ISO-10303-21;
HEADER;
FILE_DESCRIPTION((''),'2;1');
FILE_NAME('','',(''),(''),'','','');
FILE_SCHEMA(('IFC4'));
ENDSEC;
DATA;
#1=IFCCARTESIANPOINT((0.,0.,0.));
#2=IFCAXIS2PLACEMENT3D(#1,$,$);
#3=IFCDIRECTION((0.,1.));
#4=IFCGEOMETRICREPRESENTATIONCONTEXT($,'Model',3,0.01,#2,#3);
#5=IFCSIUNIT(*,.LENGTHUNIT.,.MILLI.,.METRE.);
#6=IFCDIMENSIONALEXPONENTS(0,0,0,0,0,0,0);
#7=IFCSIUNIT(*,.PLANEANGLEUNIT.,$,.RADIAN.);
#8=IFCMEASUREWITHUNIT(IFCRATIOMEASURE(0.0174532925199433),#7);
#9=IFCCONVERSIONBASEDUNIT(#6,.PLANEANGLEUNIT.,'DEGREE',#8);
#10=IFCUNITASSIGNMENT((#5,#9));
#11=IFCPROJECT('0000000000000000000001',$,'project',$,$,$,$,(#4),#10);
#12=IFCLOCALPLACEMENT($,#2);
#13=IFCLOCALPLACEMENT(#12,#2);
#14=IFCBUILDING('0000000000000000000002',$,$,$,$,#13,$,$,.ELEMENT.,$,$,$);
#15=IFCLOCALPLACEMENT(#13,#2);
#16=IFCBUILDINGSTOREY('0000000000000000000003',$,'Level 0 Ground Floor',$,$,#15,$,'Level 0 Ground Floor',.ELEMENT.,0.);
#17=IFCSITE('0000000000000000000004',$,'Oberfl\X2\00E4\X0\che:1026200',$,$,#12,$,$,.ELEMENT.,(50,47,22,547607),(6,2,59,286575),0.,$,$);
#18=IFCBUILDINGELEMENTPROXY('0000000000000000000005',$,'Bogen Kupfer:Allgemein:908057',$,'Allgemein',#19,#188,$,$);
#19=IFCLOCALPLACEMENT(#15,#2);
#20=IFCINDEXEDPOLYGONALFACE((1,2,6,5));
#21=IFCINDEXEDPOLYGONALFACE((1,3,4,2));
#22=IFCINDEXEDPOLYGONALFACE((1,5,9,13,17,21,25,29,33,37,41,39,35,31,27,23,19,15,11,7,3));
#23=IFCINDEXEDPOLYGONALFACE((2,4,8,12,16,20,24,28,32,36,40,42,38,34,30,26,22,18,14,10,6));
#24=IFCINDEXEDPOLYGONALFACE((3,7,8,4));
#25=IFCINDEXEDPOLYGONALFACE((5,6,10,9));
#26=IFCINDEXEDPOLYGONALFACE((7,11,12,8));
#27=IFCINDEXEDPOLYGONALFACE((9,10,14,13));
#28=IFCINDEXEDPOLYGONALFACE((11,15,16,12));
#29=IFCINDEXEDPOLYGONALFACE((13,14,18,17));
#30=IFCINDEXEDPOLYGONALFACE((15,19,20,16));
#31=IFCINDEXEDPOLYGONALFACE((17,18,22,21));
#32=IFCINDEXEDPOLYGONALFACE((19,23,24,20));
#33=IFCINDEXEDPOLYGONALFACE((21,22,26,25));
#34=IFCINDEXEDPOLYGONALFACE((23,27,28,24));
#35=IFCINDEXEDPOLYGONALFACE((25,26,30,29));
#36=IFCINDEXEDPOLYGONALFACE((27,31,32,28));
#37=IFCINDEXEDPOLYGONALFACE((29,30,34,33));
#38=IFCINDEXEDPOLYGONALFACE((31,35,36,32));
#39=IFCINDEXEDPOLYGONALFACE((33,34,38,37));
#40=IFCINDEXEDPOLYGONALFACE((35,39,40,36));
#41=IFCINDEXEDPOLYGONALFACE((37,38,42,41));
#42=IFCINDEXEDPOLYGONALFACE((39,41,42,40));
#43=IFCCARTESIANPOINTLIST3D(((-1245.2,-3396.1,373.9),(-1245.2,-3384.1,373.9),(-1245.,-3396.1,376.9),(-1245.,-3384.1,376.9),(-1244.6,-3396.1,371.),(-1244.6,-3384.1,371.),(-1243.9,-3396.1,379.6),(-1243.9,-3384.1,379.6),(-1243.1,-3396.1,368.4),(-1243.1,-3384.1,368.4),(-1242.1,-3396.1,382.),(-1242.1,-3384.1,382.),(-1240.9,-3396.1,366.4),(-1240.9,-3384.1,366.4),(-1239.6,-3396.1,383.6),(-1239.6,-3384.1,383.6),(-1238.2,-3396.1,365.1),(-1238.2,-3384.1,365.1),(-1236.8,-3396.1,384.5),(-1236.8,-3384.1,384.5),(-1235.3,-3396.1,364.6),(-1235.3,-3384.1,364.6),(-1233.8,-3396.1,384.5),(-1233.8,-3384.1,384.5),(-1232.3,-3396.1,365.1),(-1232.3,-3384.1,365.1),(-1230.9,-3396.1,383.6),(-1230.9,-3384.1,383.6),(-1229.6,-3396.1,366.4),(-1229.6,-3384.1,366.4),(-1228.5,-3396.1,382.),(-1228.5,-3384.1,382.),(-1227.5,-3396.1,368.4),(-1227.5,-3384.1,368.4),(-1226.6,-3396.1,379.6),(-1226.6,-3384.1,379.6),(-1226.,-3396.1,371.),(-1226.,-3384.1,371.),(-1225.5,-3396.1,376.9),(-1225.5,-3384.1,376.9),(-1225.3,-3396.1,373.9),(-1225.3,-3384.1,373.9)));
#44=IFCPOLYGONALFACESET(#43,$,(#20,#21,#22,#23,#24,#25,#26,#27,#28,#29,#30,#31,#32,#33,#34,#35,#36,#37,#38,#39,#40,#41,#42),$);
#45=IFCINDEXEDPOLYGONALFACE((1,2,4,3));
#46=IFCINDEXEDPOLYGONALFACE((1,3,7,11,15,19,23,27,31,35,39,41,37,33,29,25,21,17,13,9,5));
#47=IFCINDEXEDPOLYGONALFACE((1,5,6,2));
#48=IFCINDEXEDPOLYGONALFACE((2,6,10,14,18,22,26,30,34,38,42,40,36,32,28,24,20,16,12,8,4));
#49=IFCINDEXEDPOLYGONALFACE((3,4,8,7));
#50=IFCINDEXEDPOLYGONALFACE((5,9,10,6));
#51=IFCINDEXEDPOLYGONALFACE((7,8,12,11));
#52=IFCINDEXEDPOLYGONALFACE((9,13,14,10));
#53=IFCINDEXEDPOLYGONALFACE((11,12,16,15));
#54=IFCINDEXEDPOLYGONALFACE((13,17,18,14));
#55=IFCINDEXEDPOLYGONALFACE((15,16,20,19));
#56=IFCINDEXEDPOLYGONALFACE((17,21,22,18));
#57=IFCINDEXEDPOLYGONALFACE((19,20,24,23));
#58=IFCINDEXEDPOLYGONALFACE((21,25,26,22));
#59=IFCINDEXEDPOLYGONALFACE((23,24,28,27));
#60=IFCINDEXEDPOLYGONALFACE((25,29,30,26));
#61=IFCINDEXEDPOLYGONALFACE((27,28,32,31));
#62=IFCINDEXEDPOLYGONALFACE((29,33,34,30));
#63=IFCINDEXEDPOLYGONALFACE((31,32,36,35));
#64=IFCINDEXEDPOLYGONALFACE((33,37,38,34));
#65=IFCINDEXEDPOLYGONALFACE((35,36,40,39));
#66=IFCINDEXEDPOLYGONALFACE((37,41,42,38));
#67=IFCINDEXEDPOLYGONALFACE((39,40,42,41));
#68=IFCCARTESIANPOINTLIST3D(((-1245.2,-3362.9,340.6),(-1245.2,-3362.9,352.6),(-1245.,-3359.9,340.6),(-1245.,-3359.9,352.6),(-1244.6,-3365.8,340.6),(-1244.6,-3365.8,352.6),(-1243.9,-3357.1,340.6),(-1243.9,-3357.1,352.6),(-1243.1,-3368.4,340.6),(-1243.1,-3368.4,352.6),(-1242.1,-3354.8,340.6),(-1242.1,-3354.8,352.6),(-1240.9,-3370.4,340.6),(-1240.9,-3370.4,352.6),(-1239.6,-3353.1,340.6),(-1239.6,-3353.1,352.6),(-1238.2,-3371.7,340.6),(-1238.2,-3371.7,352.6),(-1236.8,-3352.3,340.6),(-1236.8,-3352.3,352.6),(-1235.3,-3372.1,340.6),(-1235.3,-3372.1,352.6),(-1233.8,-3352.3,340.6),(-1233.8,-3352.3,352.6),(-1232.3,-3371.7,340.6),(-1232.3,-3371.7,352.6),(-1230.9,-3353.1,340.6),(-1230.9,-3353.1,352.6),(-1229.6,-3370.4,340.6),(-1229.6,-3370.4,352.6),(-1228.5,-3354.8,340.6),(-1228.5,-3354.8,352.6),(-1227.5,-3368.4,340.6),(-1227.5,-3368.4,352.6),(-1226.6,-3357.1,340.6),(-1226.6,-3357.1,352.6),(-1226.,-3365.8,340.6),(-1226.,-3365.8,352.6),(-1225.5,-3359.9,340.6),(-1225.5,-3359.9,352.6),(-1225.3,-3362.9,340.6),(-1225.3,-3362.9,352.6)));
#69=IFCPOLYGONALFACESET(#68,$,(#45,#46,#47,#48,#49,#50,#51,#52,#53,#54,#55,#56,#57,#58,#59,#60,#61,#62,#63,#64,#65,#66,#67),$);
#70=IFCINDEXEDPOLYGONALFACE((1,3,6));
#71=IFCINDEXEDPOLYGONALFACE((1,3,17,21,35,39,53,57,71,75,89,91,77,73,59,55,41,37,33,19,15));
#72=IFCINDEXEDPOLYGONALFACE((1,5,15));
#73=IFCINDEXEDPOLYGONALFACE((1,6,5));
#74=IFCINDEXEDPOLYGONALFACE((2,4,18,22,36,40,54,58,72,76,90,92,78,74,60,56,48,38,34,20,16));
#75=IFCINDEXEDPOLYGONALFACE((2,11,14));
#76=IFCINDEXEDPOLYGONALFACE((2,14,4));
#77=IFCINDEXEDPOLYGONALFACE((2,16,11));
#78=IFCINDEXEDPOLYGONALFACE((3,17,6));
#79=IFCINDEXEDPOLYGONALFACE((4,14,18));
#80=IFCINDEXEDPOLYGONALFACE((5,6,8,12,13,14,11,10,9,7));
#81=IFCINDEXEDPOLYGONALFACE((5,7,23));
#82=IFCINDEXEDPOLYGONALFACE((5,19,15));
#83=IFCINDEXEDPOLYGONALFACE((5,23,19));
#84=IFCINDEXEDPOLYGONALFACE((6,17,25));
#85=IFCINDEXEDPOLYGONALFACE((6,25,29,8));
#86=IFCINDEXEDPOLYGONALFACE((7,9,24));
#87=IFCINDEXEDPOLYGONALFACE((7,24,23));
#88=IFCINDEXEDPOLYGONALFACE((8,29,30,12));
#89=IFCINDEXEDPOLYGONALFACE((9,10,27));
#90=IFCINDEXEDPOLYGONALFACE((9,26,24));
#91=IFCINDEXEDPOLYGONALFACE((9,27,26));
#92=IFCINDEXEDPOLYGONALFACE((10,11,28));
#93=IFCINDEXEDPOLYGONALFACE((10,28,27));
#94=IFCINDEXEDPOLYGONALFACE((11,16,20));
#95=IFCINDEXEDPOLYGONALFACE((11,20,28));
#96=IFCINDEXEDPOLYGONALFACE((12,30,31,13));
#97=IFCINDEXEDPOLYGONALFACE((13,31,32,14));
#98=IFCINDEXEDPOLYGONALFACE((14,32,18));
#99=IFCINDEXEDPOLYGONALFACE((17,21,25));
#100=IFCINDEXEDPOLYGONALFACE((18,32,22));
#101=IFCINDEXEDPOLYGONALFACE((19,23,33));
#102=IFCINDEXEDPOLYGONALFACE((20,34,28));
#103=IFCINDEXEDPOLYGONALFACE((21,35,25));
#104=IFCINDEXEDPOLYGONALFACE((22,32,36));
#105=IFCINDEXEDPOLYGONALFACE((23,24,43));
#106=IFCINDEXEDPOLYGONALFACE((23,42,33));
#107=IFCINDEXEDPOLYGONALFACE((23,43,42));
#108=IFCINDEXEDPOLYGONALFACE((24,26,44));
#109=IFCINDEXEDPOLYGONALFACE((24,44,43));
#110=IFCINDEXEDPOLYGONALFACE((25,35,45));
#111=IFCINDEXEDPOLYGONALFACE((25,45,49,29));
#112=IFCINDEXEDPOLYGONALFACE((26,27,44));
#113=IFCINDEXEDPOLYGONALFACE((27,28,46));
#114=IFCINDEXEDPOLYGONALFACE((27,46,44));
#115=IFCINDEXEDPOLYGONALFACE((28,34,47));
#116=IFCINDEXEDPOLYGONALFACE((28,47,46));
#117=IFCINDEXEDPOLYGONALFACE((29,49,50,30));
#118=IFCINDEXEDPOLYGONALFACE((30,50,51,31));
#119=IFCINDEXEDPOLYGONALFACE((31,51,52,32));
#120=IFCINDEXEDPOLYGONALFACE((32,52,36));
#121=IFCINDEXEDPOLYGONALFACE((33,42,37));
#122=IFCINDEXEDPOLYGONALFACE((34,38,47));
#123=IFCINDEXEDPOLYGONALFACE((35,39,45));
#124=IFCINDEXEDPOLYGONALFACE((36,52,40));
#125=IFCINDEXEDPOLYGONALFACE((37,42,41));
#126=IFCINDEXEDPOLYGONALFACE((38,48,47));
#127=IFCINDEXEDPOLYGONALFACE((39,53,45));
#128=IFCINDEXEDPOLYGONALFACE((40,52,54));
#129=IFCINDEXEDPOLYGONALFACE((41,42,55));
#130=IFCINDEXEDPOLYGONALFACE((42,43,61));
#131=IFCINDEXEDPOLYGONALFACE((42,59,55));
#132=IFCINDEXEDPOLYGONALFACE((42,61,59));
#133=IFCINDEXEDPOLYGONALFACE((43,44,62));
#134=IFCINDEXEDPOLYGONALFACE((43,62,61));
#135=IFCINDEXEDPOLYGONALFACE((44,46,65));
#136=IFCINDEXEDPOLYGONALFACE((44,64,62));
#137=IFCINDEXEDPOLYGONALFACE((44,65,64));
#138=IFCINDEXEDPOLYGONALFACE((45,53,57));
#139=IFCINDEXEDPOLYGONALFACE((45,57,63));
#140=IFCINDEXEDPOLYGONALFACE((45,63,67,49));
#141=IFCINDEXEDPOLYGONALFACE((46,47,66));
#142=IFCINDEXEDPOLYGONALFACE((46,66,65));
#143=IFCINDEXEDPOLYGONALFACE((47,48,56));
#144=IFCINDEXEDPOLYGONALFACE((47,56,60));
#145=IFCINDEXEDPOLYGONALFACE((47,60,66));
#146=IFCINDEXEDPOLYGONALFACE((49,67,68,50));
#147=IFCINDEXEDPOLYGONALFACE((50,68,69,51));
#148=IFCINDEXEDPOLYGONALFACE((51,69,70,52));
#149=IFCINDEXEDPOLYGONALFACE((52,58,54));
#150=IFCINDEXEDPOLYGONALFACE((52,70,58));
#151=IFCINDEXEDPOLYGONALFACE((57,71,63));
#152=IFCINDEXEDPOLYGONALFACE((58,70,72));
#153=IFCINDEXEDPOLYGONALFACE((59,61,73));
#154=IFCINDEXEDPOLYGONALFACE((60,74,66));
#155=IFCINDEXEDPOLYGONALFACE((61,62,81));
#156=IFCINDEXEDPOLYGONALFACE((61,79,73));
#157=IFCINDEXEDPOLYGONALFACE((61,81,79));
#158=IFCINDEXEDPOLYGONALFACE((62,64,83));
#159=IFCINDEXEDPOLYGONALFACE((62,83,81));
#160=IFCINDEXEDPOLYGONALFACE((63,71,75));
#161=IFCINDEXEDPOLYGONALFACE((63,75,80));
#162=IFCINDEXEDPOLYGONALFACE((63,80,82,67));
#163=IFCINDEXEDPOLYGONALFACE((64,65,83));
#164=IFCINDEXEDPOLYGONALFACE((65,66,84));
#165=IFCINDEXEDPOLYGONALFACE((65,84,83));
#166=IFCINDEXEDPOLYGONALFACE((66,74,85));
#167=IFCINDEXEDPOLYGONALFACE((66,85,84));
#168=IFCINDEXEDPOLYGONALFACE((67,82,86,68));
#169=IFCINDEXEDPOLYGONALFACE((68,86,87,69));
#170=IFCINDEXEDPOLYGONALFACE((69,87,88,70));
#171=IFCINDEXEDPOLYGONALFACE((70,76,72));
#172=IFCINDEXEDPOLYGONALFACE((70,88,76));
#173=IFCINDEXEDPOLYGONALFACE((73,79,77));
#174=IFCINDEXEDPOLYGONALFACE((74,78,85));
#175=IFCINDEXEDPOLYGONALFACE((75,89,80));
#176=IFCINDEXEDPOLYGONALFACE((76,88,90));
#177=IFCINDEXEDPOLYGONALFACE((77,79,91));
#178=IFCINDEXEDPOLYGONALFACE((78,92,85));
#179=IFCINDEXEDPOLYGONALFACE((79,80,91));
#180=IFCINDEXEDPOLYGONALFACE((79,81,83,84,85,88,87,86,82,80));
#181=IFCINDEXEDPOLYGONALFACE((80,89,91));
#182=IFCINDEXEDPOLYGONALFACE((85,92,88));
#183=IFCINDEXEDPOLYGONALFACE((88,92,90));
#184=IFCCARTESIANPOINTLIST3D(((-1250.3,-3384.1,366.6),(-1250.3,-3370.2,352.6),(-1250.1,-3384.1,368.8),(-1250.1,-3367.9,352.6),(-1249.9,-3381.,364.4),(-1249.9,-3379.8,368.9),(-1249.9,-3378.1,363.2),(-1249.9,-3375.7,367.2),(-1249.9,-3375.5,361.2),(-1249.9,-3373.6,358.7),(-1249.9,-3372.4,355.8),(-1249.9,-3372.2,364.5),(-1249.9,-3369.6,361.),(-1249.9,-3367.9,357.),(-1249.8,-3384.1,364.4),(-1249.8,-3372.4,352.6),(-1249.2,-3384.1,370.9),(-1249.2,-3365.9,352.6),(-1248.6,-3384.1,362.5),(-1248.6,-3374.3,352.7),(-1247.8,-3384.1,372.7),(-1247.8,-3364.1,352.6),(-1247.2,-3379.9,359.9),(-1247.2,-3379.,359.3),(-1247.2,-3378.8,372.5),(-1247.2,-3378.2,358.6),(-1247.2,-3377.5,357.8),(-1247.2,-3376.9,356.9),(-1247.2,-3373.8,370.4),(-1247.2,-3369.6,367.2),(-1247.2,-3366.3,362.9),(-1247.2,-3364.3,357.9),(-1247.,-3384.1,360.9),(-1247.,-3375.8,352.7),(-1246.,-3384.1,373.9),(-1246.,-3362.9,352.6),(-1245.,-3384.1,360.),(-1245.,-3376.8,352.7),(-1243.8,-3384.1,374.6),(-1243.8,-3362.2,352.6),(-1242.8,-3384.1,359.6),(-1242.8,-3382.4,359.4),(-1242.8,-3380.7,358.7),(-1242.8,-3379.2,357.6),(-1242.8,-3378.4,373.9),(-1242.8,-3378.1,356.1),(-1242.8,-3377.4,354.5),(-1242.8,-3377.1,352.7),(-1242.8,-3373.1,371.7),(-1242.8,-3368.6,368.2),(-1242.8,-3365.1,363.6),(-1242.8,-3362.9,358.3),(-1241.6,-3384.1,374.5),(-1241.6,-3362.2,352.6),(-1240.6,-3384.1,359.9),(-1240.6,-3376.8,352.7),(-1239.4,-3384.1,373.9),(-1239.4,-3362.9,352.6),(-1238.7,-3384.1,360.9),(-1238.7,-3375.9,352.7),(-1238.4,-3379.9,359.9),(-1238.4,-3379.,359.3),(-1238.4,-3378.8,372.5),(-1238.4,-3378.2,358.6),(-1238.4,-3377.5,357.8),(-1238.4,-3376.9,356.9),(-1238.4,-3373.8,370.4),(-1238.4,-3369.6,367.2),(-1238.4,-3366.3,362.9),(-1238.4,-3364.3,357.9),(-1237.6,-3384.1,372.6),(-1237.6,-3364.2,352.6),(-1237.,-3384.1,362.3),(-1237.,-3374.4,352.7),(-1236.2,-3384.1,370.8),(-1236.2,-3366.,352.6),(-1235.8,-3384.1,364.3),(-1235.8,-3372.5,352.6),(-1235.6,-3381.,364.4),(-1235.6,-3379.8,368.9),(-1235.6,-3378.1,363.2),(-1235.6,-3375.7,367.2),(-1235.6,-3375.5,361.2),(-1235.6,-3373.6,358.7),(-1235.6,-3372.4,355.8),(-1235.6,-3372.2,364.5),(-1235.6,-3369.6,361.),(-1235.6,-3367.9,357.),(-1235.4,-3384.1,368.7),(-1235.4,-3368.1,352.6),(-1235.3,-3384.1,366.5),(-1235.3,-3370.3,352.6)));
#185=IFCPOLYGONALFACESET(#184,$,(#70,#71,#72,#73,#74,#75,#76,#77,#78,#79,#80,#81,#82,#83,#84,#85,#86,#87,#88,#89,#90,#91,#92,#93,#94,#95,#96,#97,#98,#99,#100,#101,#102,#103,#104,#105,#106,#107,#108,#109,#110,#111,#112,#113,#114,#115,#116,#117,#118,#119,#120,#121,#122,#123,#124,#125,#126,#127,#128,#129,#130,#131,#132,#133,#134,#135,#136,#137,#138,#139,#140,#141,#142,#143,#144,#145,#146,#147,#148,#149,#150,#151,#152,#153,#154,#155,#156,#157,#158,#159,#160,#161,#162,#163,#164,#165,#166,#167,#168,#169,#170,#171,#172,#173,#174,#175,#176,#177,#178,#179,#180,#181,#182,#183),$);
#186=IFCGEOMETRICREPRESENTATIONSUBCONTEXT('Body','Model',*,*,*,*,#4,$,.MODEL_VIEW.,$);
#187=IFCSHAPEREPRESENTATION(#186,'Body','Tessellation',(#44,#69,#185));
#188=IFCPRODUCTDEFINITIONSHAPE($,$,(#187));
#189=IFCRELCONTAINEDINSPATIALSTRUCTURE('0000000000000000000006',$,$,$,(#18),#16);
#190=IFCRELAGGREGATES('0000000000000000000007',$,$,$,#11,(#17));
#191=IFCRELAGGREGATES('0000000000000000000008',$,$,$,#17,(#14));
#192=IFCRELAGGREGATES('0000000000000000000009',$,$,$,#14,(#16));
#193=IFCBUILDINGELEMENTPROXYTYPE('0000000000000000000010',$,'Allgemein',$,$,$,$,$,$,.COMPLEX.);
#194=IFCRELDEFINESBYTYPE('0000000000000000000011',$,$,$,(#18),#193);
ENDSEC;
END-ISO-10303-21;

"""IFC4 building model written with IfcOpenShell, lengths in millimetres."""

from ifc_helpers import new_model, entity, si_unit, converted_unit, direction, frame, frame_2d, origin, place, context, subcontext, project, spatial, circle, extrude, source, transform, mapped, type_object, type_shapes, element, save


model = new_model("IFC4")

# Units and contexts
model_context = context("Model", 3, precision=0.01, world=origin(), true_north=direction((0.0, 1.0)))
body_context = subcontext(model_context, "Body", "Model", "MODEL_VIEW")
ifc_project = project(units=[si_unit("LENGTHUNIT", "METRE", prefix="MILLI"), converted_unit("PLANEANGLEUNIT", "DEGREE", entity("IfcRatioMeasure", 0.0174532925199433), si_unit("PLANEANGLEUNIT", "RADIAN"), dimensions=[0, 0, 0, 0, 0, 0, 0])], contexts=[model_context])

# Site, building, storey
site_placement = place(None, origin())
site = spatial("IfcSite", under=ifc_project, at=site_placement, Name="Oberfläche:1026200", CompositionType="ELEMENT", RefLatitude=(50, 47, 22, 547607), RefLongitude=(6, 2, 59, 286575), RefElevation=0.0)
building_placement = place(site_placement, origin())
building = spatial("IfcBuilding", under=site, at=building_placement, CompositionType="ELEMENT")
storey_placement = place(building_placement, origin())
storey = spatial("IfcBuildingStorey", under=building, at=storey_placement, Name="Level 0 Ground Floor", LongName="Level 0 Ground Floor", CompositionType="ELEMENT", Elevation=0.0)

# Building element proxy
building_element_proxy_type = type_object("IfcBuildingElementProxyType", Name="Allgemein", PredefinedType="COMPLEX")
ifc_direction = entity("IfcDirection", [0.0, 0.0, -1.0])
trimmed_curve = entity("IfcTrimmedCurve", entity("IfcCircle", entity("IfcAxis2Placement2D", entity("IfcCartesianPoint", [-14.5, 0.0]), entity("IfcDirection", [0.0, 1.0])), 14.5), [entity("IfcParameterValue", 270.0)], [entity("IfcParameterValue", 0.0)], True, "PARAMETER")
shared_shape_1 = source(origin(), body_context, "Body", "SolidModel", [
    extrude(circle(Radius=10.0, at=frame_2d((0.0, 0.0), x_axis=(1.0, 0.0))), frame((0.0, 22.0, 0.0), z_axis=(0.0, 1.0, 0.0), x_axis=(-1.0, 0.0, 0.0)), (0.0, 0.0, 1.0), 12.0),
    extrude(circle(Radius=10.0, at=frame_2d((0.0, 0.0), x_axis=(1.0, 0.0))), frame((-34.0, 0.0, 0.0), z_axis=(1.0, 0.0, 0.0), x_axis=(0.0, 1.0, 0.0)), (0.0, 0.0, 1.0), 12.0),
    entity("IfcSurfaceCurveSweptAreaSolid", entity("IfcCircleProfileDef", "AREA", None, entity("IfcAxis2Placement2D", entity("IfcCartesianPoint", [0.0, 7.5]), entity("IfcDirection", [1.0, 0.0])), 7.5), entity("IfcAxis2Placement3D", entity("IfcCartesianPoint", [-7.5, 22.0, 0.0]), ifc_direction, entity("IfcDirection", [1.0, 0.0, 0.0])), trimmed_curve, 0.0, 90.0, entity("IfcSurfaceOfLinearExtrusion", entity("IfcArbitraryOpenProfileDef", "CURVE", None, trimmed_curve), entity("IfcAxis2Placement3D", entity("IfcCartesianPoint", [0.0, 0.0, -304.8])), ifc_direction, 1.0)),
])
type_shapes(building_element_proxy_type, [shared_shape_1])
for number, where, z_axis, x_axis, name in (
    (1, (-1235.3, -3362.1, 374.6), (1.0, 0.0, 0.0), (0.0, 0.0, 1.0), "Bogen Kupfer:Allgemein:908057"),
):
    element("IfcBuildingElementProxy", number, at=place(storey_placement, frame(where, z_axis=z_axis, x_axis=x_axis)), inside=storey, type_object=building_element_proxy_type, Name=name, ObjectType="Allgemein", context=body_context, shape_type="MappedRepresentation", body=[
        mapped(shared_shape_1, transform((0.0, 0.0, 0.0), scale=1.0)),
    ])

save(model, "model.ifc")
